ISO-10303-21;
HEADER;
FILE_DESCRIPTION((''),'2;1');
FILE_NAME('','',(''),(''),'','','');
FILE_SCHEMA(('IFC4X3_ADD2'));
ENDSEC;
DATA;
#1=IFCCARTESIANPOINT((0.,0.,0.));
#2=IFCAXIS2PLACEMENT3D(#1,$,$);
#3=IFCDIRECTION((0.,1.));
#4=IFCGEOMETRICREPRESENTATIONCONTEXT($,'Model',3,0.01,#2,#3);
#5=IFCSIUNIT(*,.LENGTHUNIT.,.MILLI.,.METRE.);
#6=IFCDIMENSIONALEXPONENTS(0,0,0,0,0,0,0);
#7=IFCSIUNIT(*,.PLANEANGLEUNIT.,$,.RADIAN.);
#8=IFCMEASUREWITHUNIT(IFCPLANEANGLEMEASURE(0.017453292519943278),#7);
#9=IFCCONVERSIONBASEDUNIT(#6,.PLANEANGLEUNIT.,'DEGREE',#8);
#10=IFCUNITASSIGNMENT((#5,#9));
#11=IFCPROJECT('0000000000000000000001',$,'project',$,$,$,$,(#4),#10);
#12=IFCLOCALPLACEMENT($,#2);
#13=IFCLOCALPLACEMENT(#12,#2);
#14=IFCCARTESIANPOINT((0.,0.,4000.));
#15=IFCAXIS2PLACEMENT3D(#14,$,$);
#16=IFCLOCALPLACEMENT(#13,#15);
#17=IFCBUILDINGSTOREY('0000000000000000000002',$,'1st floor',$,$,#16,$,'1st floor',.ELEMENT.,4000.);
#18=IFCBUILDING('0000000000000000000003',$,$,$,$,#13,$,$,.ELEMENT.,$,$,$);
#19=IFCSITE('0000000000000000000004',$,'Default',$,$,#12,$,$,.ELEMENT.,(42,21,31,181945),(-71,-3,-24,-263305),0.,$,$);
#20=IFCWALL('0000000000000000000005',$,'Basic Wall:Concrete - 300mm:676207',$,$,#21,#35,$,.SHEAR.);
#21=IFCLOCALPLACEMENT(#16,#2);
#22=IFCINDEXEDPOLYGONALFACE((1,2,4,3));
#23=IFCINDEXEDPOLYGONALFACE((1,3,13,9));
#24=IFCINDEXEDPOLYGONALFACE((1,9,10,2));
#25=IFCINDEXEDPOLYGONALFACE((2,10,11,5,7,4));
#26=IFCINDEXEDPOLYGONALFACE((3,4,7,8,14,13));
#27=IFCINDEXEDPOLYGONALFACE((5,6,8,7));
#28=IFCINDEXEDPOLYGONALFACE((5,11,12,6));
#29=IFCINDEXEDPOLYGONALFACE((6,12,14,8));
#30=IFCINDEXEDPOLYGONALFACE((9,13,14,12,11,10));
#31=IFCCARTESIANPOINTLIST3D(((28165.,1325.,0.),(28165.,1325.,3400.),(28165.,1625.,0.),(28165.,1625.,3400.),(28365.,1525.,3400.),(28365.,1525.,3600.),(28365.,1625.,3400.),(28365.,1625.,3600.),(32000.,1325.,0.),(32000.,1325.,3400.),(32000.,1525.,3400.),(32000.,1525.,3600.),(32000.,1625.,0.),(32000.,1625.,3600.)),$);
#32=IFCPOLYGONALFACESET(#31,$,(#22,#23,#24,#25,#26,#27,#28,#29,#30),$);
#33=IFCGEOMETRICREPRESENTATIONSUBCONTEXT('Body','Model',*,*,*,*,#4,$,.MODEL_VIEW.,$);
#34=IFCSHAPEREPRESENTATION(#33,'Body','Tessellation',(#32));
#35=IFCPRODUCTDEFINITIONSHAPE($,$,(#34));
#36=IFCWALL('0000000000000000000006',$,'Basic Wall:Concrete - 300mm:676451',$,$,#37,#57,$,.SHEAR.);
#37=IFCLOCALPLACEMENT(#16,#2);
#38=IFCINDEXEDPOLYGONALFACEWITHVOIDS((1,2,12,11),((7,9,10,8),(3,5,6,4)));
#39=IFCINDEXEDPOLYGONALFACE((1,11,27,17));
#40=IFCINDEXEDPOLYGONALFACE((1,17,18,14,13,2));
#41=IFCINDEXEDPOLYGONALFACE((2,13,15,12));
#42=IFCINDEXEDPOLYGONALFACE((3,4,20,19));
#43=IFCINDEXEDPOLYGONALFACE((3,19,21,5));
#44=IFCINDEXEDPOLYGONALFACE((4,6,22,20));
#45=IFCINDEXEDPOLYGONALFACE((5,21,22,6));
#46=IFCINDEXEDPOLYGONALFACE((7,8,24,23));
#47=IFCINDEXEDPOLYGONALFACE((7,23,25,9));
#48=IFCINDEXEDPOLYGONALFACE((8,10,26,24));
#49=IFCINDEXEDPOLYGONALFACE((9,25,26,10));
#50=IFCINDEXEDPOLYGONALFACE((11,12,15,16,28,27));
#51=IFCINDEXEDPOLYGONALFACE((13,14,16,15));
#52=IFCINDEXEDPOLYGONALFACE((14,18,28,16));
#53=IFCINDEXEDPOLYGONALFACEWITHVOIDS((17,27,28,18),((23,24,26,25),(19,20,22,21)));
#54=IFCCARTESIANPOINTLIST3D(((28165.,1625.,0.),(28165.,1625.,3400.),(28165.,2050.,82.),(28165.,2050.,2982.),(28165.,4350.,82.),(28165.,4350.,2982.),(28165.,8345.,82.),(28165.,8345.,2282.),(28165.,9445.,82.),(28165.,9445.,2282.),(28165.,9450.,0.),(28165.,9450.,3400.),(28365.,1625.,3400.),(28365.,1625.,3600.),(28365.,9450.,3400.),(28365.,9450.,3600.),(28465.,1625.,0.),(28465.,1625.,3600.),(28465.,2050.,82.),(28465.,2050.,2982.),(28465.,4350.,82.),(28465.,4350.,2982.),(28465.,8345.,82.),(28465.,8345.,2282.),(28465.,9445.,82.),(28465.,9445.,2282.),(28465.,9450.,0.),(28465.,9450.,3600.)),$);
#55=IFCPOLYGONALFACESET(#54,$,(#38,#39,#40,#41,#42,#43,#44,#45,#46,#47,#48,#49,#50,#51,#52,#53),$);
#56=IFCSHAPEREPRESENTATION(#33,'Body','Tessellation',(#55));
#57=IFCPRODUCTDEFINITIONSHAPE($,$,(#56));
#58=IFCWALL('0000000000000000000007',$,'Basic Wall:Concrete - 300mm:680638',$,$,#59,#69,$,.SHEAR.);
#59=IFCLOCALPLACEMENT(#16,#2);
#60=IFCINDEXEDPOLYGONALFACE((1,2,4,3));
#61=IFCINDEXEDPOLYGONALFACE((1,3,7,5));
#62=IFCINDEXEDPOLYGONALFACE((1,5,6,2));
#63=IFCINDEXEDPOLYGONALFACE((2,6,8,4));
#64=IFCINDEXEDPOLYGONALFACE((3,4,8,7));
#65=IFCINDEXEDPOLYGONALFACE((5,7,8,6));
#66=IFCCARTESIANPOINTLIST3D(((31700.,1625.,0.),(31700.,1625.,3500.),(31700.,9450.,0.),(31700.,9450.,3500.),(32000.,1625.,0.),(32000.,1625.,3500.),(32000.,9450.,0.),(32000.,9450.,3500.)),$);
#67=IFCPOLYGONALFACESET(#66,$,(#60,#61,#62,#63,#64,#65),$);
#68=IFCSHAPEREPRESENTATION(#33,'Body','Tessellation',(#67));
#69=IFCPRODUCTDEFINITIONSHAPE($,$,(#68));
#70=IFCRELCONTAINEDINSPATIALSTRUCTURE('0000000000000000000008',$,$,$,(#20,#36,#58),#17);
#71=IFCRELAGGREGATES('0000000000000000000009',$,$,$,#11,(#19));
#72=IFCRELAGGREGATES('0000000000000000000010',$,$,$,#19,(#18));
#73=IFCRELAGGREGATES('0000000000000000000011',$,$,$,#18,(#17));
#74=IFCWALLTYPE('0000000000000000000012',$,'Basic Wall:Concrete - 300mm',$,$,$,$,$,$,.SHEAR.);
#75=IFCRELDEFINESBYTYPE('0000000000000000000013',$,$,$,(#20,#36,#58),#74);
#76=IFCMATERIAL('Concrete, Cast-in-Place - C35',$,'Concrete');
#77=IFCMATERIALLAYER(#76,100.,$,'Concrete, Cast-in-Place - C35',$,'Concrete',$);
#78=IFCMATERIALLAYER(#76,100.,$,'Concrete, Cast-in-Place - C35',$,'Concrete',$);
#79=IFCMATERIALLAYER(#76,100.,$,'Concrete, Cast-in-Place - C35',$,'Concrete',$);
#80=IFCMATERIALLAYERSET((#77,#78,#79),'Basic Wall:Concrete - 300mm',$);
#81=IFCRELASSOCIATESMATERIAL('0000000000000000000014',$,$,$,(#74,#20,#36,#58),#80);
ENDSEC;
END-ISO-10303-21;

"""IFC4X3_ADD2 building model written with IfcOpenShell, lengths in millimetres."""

from ifc_helpers import new_model, entity, si_unit, converted_unit, direction, frame, frame_2d, origin, place, context, subcontext, project, spatial, polyline, rectangle, extrude, clip, bounded_halfspace, material, layer, layer_set, type_object, element, save


model = new_model("IFC4X3_ADD2")

# Units and contexts
model_context = context("Model", 3, precision=0.01, world=origin(), true_north=direction((0.0, 1.0)))
body_context = subcontext(model_context, "Body", "Model", "MODEL_VIEW")
ifc_project = project(units=[si_unit("LENGTHUNIT", "METRE", prefix="MILLI"), converted_unit("PLANEANGLEUNIT", "DEGREE", entity("IfcPlaneAngleMeasure", 0.017453292519943278), si_unit("PLANEANGLEUNIT", "RADIAN"), dimensions=[0, 0, 0, 0, 0, 0, 0])], contexts=[model_context])

# Site, building, storey
site_placement = place(None, origin())
site = spatial("IfcSite", under=ifc_project, at=site_placement, Name="Default", CompositionType="ELEMENT", RefLatitude=(42, 21, 31, 181945), RefLongitude=(-71, -3, -24, -263305), RefElevation=0.0)
building_placement = place(site_placement, origin())
building = spatial("IfcBuilding", under=site, at=building_placement, CompositionType="ELEMENT")
storey_placement = place(building_placement, frame((0.0, 0.0, 4000.0)))
storey = spatial("IfcBuildingStorey", under=building, at=storey_placement, Name="1st floor", LongName="1st floor", CompositionType="ELEMENT", Elevation=4000.0)

# Shared definitions
ifc_material_1 = material(Name="Concrete, Cast-in-Place - C35", Category="Concrete")

# Wall
ifc_layer_1 = layer(ifc_material_1, 100.0, Name="Concrete, Cast-in-Place - C35", Category="Concrete")
ifc_layer_2 = layer(ifc_material_1, 100.0, Name="Concrete, Cast-in-Place - C35", Category="Concrete")
ifc_layer_3 = layer(ifc_material_1, 100.0, Name="Concrete, Cast-in-Place - C35", Category="Concrete")
ifc_layer_set = layer_set([ifc_layer_1, ifc_layer_2, ifc_layer_3], Name="Basic Wall:Concrete - 300mm")
wall_type = type_object("IfcWallType", Name="Basic Wall:Concrete - 300mm", PredefinedType="SHEAR", material=ifc_layer_set)
wall_1_placement = place(storey_placement, frame((32000.0, 1475.0, 0.0), z_axis=(0.0, 0.0, 1.0), x_axis=(-1.0, 0.0, 0.0)))
element("IfcWall", 1, at=wall_1_placement, inside=storey, type_object=wall_type, material=ifc_layer_set, Name="Basic Wall:Concrete - 300mm:676207", PredefinedType="SHEAR", context=body_context, shape_type="Clipping", body=[
    clip(extrude(rectangle(XDim=3835.0, YDim=300.0, at=frame_2d((1917.5, 0.0), x_axis=(-1.0, 0.0))), origin(), (0.0, 0.0, 1.0), 3600.0), bounded_halfspace(frame((3835.0, 150.0, 3400.0), z_axis=(0.0, 0.0, 1.0), x_axis=(-1.0, 0.0, 0.0)), False, frame((3835.0, 150.0, 3400.0)), polyline([(0.0, 0.0), (-3835.0, 0.0), (-3835.0, -200.0), (-200.0, -200.0), (-200.0, -300.0), (0.0, -300.0), (0.0, 0.0)]))),
])

# Wall, openings
wall_2_placement = place(storey_placement, frame((28315.0, 1625.0, 0.0), z_axis=(0.0, 0.0, 1.0), x_axis=(0.0, 1.0, 0.0)))
wall_2 = element("IfcWall", 2, at=wall_2_placement, inside=storey, type_object=wall_type, material=ifc_layer_set, Name="Basic Wall:Concrete - 300mm:676451", PredefinedType="SHEAR", context=body_context, shape_type="Clipping", body=[
    clip(extrude(rectangle(XDim=7825.0, YDim=300.0, at=frame_2d((3912.5, 0.0), x_axis=(-1.0, 0.0))), origin(), (0.0, 0.0, 1.0), 3600.0), bounded_halfspace(frame((7825.0, 150.0, 3400.0), z_axis=(0.0, 0.0, 1.0), x_axis=(0.0, -1.0, 0.0)), False, frame((7825.0, 150.0, 3400.0)), polyline([(0.0, 0.0), (-7825.0, 0.0), (-7825.0, -200.0), (0.0, -200.0), (0.0, 0.0)]))),
])
opening_1_placement = place(wall_2_placement, frame((-1625.0, 28315.0, 82.0)))
element("IfcOpeningElement", 3, at=opening_1_placement, cuts=wall_2, PredefinedType="OPENING", context=body_context, shape_type="SweptSolid", body=[
    extrude(rectangle(XDim=2200.0, YDim=1100.0, at=frame_2d((0.0, 0.0), x_axis=(0.0, 1.0))), frame((8895.0, -28615.0, 1100.0), z_axis=(0.0, 1.0, 0.0), x_axis=(-1.0, 0.0, 0.0)), (0.0, 0.0, 1.0), 600.0),
])
opening_2_placement = place(wall_2_placement, frame((-1625.0, 28315.0, 82.0)))
element("IfcOpeningElement", 4, at=opening_2_placement, cuts=wall_2, PredefinedType="OPENING", context=body_context, shape_type="SweptSolid", body=[
    extrude(rectangle(XDim=2900.0, YDim=2300.0, at=frame_2d((0.0, 0.0), x_axis=(0.0, 1.0))), frame((3200.0, -28615.0, 1450.0), z_axis=(0.0, 1.0, 0.0), x_axis=(-1.0, 0.0, 0.0)), (0.0, 0.0, 1.0), 600.0),
])

# Wall
wall_3_placement = place(storey_placement, frame((31850.0, 9450.0, 0.0), z_axis=(0.0, 0.0, 1.0), x_axis=(0.0, -1.0, 0.0)))
element("IfcWall", 5, at=wall_3_placement, inside=storey, type_object=wall_type, material=ifc_layer_set, Name="Basic Wall:Concrete - 300mm:680638", PredefinedType="SHEAR", context=body_context, shape_type="SweptSolid", body=[
    extrude(rectangle(XDim=7825.0, YDim=300.0, at=frame_2d((3912.5, 0.0), x_axis=(-1.0, 0.0))), origin(), (0.0, 0.0, 1.0), 3500.0),
])

save(model, "model.ifc")
